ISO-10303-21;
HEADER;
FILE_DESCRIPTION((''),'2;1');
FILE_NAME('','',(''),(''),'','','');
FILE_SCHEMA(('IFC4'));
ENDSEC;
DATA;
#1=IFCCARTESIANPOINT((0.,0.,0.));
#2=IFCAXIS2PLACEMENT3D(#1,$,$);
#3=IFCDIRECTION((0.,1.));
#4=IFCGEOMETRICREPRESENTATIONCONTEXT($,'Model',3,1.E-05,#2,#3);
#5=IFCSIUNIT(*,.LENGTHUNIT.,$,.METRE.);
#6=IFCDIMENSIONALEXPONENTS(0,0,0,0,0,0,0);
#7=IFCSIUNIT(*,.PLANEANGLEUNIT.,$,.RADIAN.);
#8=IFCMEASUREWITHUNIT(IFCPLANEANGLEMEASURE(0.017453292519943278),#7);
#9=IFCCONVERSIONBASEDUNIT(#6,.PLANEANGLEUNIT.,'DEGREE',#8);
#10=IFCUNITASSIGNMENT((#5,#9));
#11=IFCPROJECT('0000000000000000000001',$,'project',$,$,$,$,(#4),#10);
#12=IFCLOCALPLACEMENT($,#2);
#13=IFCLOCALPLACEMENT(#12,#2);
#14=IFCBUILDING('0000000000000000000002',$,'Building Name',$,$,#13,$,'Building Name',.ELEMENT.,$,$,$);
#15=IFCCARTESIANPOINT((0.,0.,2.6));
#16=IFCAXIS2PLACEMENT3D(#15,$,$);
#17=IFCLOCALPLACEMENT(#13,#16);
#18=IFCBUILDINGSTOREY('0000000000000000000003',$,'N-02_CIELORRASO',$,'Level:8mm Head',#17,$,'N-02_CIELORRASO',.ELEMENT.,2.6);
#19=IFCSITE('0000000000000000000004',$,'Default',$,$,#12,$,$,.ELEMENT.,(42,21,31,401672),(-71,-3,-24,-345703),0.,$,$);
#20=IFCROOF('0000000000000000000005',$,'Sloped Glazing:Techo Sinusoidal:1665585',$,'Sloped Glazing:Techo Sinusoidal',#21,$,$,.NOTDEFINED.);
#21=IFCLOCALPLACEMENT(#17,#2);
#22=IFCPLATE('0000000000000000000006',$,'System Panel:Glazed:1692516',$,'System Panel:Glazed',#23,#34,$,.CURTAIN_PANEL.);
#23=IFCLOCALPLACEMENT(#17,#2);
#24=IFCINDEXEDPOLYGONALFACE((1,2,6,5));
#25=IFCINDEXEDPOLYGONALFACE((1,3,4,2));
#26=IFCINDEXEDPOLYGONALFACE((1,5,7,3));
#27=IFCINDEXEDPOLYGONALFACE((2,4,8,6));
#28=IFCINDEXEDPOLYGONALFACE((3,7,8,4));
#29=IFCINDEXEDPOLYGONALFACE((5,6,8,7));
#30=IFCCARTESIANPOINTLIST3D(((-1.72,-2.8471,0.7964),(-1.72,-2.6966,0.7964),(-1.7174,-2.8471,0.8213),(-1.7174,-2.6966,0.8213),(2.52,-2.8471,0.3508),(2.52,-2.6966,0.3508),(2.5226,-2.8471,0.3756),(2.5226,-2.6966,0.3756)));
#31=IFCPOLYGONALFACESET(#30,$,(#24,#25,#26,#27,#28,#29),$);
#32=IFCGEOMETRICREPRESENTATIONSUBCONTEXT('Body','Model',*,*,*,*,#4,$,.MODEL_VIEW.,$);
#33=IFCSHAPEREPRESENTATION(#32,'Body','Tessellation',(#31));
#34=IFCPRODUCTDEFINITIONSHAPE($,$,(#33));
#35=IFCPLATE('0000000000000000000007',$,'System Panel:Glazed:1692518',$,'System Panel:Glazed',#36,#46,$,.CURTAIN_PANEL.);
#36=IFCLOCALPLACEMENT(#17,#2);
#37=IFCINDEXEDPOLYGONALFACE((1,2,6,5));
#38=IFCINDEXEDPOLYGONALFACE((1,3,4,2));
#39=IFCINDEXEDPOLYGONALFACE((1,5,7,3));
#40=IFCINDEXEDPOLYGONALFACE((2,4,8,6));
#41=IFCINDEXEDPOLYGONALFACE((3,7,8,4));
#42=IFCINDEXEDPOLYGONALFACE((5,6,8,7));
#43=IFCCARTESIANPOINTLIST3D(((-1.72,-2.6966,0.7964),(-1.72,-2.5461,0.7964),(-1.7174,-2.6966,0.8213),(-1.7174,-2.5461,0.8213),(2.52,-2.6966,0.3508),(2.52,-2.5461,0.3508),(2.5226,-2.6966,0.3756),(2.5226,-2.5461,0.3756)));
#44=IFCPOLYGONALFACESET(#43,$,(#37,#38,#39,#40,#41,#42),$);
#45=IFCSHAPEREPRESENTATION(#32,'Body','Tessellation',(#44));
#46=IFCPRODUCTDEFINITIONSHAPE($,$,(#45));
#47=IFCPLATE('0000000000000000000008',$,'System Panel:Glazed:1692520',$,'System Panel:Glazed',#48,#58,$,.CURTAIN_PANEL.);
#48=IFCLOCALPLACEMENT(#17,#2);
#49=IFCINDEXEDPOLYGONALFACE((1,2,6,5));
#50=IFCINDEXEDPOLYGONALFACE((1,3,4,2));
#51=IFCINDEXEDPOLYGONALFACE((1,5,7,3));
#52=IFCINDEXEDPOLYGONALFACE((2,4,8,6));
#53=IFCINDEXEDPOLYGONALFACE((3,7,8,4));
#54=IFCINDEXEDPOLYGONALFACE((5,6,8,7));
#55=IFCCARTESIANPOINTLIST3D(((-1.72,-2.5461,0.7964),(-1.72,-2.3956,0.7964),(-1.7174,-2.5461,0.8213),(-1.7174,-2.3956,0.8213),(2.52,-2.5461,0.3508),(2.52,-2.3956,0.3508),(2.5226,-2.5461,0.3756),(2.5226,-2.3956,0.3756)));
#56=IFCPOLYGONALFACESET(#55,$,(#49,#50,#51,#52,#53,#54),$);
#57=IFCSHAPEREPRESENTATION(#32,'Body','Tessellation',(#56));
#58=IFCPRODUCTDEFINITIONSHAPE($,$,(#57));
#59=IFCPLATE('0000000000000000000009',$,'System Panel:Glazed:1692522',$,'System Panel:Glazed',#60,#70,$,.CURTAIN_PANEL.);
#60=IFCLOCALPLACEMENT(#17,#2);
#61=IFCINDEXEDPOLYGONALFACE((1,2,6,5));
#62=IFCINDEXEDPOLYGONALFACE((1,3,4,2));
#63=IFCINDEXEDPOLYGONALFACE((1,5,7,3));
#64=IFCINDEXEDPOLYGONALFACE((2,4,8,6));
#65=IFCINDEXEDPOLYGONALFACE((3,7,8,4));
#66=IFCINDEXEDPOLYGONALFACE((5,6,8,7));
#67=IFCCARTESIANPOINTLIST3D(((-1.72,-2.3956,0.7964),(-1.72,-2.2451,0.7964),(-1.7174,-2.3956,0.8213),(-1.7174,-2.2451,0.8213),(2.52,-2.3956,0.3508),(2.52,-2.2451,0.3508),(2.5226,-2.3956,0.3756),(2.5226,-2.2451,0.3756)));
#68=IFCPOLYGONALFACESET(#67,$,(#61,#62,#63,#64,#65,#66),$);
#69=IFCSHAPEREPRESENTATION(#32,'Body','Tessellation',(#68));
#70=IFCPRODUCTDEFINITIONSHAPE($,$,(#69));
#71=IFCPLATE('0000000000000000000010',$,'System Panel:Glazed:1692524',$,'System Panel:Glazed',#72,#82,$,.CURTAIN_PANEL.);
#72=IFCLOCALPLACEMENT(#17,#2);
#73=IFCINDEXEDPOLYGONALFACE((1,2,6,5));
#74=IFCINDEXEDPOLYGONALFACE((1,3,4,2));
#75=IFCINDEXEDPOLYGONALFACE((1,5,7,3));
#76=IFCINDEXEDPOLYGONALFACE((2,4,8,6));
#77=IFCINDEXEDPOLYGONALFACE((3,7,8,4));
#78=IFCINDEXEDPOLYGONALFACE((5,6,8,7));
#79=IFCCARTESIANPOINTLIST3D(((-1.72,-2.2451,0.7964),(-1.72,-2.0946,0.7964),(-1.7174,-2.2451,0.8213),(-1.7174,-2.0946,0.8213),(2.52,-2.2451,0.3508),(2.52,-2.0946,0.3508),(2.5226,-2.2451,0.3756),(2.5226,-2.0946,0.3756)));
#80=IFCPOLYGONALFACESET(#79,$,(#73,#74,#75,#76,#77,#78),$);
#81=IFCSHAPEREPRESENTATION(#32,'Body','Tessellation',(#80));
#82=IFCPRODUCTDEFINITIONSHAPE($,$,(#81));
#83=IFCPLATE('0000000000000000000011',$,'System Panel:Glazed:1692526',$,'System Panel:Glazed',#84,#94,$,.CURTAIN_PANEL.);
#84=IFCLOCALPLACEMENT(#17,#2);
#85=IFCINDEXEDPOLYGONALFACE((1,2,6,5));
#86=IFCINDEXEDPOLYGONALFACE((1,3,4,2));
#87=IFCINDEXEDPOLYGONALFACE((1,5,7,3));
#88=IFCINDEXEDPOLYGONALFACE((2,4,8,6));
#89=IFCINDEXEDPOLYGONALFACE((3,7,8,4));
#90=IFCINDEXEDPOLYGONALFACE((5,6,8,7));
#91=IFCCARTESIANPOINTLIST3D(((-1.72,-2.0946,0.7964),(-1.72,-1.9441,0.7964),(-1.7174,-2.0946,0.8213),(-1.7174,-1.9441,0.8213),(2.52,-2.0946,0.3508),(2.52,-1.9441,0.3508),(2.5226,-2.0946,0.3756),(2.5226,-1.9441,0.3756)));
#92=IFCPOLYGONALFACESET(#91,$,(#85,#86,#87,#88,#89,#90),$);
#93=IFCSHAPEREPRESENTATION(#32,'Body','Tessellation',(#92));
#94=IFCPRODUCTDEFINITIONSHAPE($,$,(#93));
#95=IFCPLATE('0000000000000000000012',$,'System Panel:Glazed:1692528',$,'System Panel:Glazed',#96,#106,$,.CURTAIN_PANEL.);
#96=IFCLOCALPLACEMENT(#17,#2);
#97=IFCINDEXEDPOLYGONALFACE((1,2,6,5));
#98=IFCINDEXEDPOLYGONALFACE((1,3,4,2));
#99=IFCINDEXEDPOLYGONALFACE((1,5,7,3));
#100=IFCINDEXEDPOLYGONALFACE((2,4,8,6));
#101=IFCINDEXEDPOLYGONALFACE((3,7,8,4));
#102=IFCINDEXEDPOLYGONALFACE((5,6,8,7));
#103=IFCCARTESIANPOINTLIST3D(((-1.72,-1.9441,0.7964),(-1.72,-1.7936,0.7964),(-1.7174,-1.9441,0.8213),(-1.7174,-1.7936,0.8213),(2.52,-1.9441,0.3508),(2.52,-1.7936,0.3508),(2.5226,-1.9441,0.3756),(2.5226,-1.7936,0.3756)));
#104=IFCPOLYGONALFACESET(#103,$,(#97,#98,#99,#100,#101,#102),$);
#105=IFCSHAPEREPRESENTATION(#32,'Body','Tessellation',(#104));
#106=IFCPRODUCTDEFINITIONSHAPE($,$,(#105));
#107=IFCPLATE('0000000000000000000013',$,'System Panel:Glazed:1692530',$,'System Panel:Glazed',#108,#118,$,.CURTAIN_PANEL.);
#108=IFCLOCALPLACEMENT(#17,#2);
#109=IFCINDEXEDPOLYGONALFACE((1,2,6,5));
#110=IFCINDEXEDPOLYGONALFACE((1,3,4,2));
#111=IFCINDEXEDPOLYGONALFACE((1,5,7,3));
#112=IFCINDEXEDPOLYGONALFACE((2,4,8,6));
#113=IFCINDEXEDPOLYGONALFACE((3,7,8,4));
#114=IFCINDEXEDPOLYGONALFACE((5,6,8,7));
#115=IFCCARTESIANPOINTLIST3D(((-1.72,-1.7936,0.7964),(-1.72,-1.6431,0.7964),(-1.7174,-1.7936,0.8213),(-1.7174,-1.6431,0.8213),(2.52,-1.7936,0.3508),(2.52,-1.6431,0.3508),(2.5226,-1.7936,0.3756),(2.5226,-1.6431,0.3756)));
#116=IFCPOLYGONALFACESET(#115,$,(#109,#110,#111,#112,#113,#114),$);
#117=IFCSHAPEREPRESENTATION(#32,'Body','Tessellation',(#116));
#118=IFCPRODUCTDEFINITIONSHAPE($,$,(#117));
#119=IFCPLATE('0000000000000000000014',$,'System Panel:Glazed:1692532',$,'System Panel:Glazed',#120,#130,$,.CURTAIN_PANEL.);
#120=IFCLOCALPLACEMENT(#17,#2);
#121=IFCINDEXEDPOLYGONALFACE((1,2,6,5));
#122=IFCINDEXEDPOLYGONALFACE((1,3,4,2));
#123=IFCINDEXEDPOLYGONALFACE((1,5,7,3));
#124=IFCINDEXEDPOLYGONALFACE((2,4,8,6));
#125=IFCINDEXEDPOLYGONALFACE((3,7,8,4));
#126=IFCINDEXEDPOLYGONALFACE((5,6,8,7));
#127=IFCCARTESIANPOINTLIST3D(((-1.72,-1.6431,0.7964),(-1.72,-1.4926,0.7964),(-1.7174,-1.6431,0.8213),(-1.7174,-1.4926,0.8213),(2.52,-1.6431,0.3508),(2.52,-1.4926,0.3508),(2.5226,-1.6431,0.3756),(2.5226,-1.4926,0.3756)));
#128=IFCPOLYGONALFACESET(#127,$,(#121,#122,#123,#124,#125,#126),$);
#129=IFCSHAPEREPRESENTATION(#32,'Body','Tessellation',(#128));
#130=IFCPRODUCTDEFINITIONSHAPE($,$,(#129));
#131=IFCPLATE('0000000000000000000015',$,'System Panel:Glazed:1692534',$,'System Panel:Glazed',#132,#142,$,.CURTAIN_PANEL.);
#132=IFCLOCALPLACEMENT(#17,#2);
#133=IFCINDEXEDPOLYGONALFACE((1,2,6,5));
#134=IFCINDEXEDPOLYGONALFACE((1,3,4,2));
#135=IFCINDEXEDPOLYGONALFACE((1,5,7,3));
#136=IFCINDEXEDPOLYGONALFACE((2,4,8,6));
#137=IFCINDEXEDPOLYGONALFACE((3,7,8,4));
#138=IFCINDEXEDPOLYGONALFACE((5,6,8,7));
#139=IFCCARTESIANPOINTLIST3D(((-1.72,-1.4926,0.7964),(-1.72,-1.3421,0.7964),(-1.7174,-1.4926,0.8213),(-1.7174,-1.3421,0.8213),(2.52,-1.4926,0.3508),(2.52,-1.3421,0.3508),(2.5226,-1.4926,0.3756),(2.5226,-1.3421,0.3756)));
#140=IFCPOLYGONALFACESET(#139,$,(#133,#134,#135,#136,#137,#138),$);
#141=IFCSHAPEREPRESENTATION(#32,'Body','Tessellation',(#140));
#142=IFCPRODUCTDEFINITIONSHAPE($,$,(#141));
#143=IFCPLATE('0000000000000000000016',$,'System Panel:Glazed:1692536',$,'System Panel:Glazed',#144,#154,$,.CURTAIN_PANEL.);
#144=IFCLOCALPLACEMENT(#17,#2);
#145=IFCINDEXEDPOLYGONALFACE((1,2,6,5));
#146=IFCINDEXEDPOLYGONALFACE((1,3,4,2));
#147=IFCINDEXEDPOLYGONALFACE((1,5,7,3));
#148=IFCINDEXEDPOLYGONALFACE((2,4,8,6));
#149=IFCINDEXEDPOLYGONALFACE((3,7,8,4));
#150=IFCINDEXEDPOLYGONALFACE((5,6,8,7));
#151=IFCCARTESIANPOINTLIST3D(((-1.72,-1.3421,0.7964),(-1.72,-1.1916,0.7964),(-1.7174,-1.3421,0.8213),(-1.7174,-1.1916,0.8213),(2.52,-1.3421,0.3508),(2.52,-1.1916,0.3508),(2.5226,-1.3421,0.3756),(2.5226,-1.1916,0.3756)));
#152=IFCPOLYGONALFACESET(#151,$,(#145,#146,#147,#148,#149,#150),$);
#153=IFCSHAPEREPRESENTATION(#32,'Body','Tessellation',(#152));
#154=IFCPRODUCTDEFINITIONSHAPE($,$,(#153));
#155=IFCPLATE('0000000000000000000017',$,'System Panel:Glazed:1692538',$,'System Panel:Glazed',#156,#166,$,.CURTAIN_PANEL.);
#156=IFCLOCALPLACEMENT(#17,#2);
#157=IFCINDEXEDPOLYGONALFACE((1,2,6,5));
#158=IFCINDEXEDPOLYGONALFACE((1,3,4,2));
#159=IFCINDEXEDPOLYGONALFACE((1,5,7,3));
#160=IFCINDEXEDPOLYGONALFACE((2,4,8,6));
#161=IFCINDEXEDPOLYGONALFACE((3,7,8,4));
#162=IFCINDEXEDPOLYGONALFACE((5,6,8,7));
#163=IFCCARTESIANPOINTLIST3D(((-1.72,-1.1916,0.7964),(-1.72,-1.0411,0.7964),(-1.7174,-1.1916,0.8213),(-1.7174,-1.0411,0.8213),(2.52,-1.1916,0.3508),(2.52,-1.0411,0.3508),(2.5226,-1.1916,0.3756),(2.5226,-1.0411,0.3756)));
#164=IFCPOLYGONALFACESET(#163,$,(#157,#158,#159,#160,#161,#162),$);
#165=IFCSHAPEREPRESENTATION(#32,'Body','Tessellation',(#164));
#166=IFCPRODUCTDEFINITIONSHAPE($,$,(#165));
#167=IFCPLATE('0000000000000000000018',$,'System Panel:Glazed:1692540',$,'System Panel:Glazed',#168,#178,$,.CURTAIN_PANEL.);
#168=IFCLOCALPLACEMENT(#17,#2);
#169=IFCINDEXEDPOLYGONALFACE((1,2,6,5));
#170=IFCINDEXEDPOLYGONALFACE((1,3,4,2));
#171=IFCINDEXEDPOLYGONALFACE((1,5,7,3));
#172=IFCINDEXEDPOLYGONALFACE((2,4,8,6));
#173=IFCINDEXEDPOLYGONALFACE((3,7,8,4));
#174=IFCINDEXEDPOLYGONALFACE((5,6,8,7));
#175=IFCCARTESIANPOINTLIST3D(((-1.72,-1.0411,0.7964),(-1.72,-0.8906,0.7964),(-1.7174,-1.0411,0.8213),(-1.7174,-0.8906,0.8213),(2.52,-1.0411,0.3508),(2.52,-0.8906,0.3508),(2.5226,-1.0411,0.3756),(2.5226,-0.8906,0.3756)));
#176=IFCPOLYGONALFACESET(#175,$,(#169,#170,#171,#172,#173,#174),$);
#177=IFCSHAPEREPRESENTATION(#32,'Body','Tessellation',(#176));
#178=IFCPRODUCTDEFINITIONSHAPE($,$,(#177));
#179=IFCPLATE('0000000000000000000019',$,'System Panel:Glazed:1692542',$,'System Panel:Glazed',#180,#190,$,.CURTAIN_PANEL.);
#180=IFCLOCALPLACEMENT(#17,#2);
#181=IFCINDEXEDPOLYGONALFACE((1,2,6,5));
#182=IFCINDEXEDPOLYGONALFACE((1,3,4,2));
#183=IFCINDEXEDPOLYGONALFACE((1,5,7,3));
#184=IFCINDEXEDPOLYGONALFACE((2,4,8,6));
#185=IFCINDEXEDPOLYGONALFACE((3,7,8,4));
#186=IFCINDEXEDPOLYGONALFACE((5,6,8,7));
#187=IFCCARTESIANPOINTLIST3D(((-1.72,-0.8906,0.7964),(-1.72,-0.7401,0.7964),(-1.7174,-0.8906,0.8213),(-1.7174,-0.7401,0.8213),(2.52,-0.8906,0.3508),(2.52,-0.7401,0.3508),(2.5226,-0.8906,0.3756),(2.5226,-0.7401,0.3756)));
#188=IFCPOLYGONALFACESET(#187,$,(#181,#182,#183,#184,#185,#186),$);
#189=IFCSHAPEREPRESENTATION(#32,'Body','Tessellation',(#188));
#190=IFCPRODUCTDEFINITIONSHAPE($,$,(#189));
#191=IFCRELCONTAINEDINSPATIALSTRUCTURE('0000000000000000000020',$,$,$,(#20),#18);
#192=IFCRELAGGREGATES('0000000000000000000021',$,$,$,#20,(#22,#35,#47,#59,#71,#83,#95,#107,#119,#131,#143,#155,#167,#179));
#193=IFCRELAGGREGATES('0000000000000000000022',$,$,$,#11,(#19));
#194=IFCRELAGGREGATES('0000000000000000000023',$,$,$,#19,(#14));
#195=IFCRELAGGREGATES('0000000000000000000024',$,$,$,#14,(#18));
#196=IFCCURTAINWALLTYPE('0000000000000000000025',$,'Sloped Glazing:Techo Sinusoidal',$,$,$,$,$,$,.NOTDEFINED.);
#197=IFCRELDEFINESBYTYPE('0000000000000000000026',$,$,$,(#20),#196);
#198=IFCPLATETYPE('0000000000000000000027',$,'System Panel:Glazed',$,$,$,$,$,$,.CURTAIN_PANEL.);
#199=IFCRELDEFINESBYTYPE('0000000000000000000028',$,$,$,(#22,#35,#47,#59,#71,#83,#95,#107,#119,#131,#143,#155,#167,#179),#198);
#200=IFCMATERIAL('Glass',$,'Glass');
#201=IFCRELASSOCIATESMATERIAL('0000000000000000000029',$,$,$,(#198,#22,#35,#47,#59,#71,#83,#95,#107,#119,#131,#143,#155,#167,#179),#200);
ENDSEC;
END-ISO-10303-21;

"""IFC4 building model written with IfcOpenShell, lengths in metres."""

from ifc_helpers import new_model, entity, si_unit, converted_unit, direction, frame, origin, place, context, subcontext, project, spatial, indexed_curve, outline, extrude, source, transform, mapped, material, type_object, type_shapes, element, aggregate, save


model = new_model("IFC4")

# Units and contexts
model_context = context("Model", 3, precision=1e-05, world=origin(), true_north=direction((0.0, 1.0)))
body_context = subcontext(model_context, "Body", "Model", "MODEL_VIEW")
ifc_project = project(units=[si_unit("LENGTHUNIT", "METRE"), converted_unit("PLANEANGLEUNIT", "DEGREE", entity("IfcPlaneAngleMeasure", 0.017453292519943278), si_unit("PLANEANGLEUNIT", "RADIAN"), dimensions=[0, 0, 0, 0, 0, 0, 0])], contexts=[model_context])

# Site, building, storey
site_placement = place(None, origin())
site = spatial("IfcSite", under=ifc_project, at=site_placement, Name="Default", CompositionType="ELEMENT", RefLatitude=(42, 21, 31, 401672), RefLongitude=(-71, -3, -24, -345703), RefElevation=0.0)
building_placement = place(site_placement, origin())
building = spatial("IfcBuilding", under=site, at=building_placement, Name="Building Name", LongName="Building Name", CompositionType="ELEMENT")
storey_placement = place(building_placement, frame((0.0, 0.0, 2.6)))
storey = spatial("IfcBuildingStorey", under=building, at=storey_placement, Name="N-02_CIELORRASO", ObjectType="Level:8mm Head", LongName="N-02_CIELORRASO", CompositionType="ELEMENT", Elevation=2.6)

# Roof, plates
curtain_wall_type = type_object("IfcCurtainWallType", Name="Sloped Glazing:Techo Sinusoidal", PredefinedType="NOTDEFINED")
roof_placement = place(storey_placement, frame((0.0, 0.0, -2.6)))
roof = element("IfcRoof", 1, at=roof_placement, inside=storey, type_object=curtain_wall_type, Name="Sloped Glazing:Techo Sinusoidal:1665585", ObjectType="Sloped Glazing:Techo Sinusoidal", PredefinedType="NOTDEFINED")
ifc_material_1 = material(Name="Glass", Category="Glass")
plate_type = type_object("IfcPlateType", Name="System Panel:Glazed", PredefinedType="CURTAIN_PANEL", material=ifc_material_1)
shared_shape_1 = source(origin(), body_context, "Body", "SweptSolid", [
    extrude(outline(indexed_curve([(-0.0125, -0.0752), (0.0125, -0.0752), (0.0125, 0.0752), (-0.0125, 0.0752), (-0.0125, -0.0752)], self_intersect=False)), frame((0.0, 0.037, 0.0), z_axis=(0.0, 0.0, 1.0), x_axis=(0.0, 1.0, 0.0)), (0.0, 0.0, 1.0), 4.2634),
])
type_shapes(plate_type, [shared_shape_1])
plate_1_placement = place(roof_placement, frame((2.5252, -2.7719, 3.0), z_axis=(-0.994522, 0.0, 0.104528), x_axis=(0.0, 1.0, 0.0)))
plate_1 = element("IfcPlate", 2, at=plate_1_placement, type_object=plate_type, material=ifc_material_1, Name="System Panel:Glazed:1692516", ObjectType="System Panel:Glazed", PredefinedType="CURTAIN_PANEL", context=body_context, shape_type="MappedRepresentation", body=[
    mapped(shared_shape_1, transform((0.0, 0.0, 0.0), scale=1.0)),
])
plate_2_placement = place(roof_placement, frame((2.5252, -2.6214, 3.0), z_axis=(-0.994522, 0.0, 0.104528), x_axis=(0.0, 1.0, 0.0)))
plate_2 = element("IfcPlate", 3, at=plate_2_placement, type_object=plate_type, material=ifc_material_1, Name="System Panel:Glazed:1692518", ObjectType="System Panel:Glazed", PredefinedType="CURTAIN_PANEL", context=body_context, shape_type="MappedRepresentation", body=[
    mapped(shared_shape_1, transform((0.0, 0.0, 0.0), scale=1.0)),
])
plate_3_placement = place(roof_placement, frame((2.5252, -2.4709, 3.0), z_axis=(-0.994522, 0.0, 0.104528), x_axis=(0.0, 1.0, 0.0)))
plate_3 = element("IfcPlate", 4, at=plate_3_placement, type_object=plate_type, material=ifc_material_1, Name="System Panel:Glazed:1692520", ObjectType="System Panel:Glazed", PredefinedType="CURTAIN_PANEL", context=body_context, shape_type="MappedRepresentation", body=[
    mapped(shared_shape_1, transform((0.0, 0.0, 0.0), scale=1.0)),
])
plate_4_placement = place(roof_placement, frame((2.5252, -2.3204, 3.0), z_axis=(-0.994522, 0.0, 0.104528), x_axis=(0.0, 1.0, 0.0)))
plate_4 = element("IfcPlate", 5, at=plate_4_placement, type_object=plate_type, material=ifc_material_1, Name="System Panel:Glazed:1692522", ObjectType="System Panel:Glazed", PredefinedType="CURTAIN_PANEL", context=body_context, shape_type="MappedRepresentation", body=[
    mapped(shared_shape_1, transform((0.0, 0.0, 0.0), scale=1.0)),
])
plate_5_placement = place(roof_placement, frame((2.5252, -2.1699, 3.0), z_axis=(-0.994522, 0.0, 0.104528), x_axis=(0.0, 1.0, 0.0)))
plate_5 = element("IfcPlate", 6, at=plate_5_placement, type_object=plate_type, material=ifc_material_1, Name="System Panel:Glazed:1692524", ObjectType="System Panel:Glazed", PredefinedType="CURTAIN_PANEL", context=body_context, shape_type="MappedRepresentation", body=[
    mapped(shared_shape_1, transform((0.0, 0.0, 0.0), scale=1.0)),
])
plate_6_placement = place(roof_placement, frame((2.5252, -2.0194, 3.0), z_axis=(-0.994522, 0.0, 0.104528), x_axis=(0.0, 1.0, 0.0)))
plate_6 = element("IfcPlate", 7, at=plate_6_placement, type_object=plate_type, material=ifc_material_1, Name="System Panel:Glazed:1692526", ObjectType="System Panel:Glazed", PredefinedType="CURTAIN_PANEL", context=body_context, shape_type="MappedRepresentation", body=[
    mapped(shared_shape_1, transform((0.0, 0.0, 0.0), scale=1.0)),
])
plate_7_placement = place(roof_placement, frame((2.5252, -1.8689, 3.0), z_axis=(-0.994522, 0.0, 0.104528), x_axis=(0.0, 1.0, 0.0)))
plate_7 = element("IfcPlate", 8, at=plate_7_placement, type_object=plate_type, material=ifc_material_1, Name="System Panel:Glazed:1692528", ObjectType="System Panel:Glazed", PredefinedType="CURTAIN_PANEL", context=body_context, shape_type="MappedRepresentation", body=[
    mapped(shared_shape_1, transform((0.0, 0.0, 0.0), scale=1.0)),
])
plate_8_placement = place(roof_placement, frame((2.5252, -1.7184, 3.0), z_axis=(-0.994522, 0.0, 0.104528), x_axis=(0.0, 1.0, 0.0)))
plate_8 = element("IfcPlate", 9, at=plate_8_placement, type_object=plate_type, material=ifc_material_1, Name="System Panel:Glazed:1692530", ObjectType="System Panel:Glazed", PredefinedType="CURTAIN_PANEL", context=body_context, shape_type="MappedRepresentation", body=[
    mapped(shared_shape_1, transform((0.0, 0.0, 0.0), scale=1.0)),
])
plate_9_placement = place(roof_placement, frame((2.5252, -1.5679, 3.0), z_axis=(-0.994522, 0.0, 0.104528), x_axis=(0.0, 1.0, 0.0)))
plate_9 = element("IfcPlate", 10, at=plate_9_placement, type_object=plate_type, material=ifc_material_1, Name="System Panel:Glazed:1692532", ObjectType="System Panel:Glazed", PredefinedType="CURTAIN_PANEL", context=body_context, shape_type="MappedRepresentation", body=[
    mapped(shared_shape_1, transform((0.0, 0.0, 0.0), scale=1.0)),
])
plate_10_placement = place(roof_placement, frame((2.5252, -1.4174, 3.0), z_axis=(-0.994522, 0.0, 0.104528), x_axis=(0.0, 1.0, 0.0)))
plate_10 = element("IfcPlate", 11, at=plate_10_placement, type_object=plate_type, material=ifc_material_1, Name="System Panel:Glazed:1692534", ObjectType="System Panel:Glazed", PredefinedType="CURTAIN_PANEL", context=body_context, shape_type="MappedRepresentation", body=[
    mapped(shared_shape_1, transform((0.0, 0.0, 0.0), scale=1.0)),
])
plate_11_placement = place(roof_placement, frame((2.5252, -1.2669, 3.0), z_axis=(-0.994522, 0.0, 0.104528), x_axis=(0.0, 1.0, 0.0)))
plate_11 = element("IfcPlate", 12, at=plate_11_placement, type_object=plate_type, material=ifc_material_1, Name="System Panel:Glazed:1692536", ObjectType="System Panel:Glazed", PredefinedType="CURTAIN_PANEL", context=body_context, shape_type="MappedRepresentation", body=[
    mapped(shared_shape_1, transform((0.0, 0.0, 0.0), scale=1.0)),
])
plate_12_placement = place(roof_placement, frame((2.5252, -1.1164, 3.0), z_axis=(-0.994522, 0.0, 0.104528), x_axis=(0.0, 1.0, 0.0)))
plate_12 = element("IfcPlate", 13, at=plate_12_placement, type_object=plate_type, material=ifc_material_1, Name="System Panel:Glazed:1692538", ObjectType="System Panel:Glazed", PredefinedType="CURTAIN_PANEL", context=body_context, shape_type="MappedRepresentation", body=[
    mapped(shared_shape_1, transform((0.0, 0.0, 0.0), scale=1.0)),
])
plate_13_placement = place(roof_placement, frame((2.5252, -0.9659, 3.0), z_axis=(-0.994522, 0.0, 0.104528), x_axis=(0.0, 1.0, 0.0)))
plate_13 = element("IfcPlate", 14, at=plate_13_placement, type_object=plate_type, material=ifc_material_1, Name="System Panel:Glazed:1692540", ObjectType="System Panel:Glazed", PredefinedType="CURTAIN_PANEL", context=body_context, shape_type="MappedRepresentation", body=[
    mapped(shared_shape_1, transform((0.0, 0.0, 0.0), scale=1.0)),
])
plate_14_placement = place(roof_placement, frame((2.5252, -0.8154, 3.0), z_axis=(-0.994522, 0.0, 0.104528), x_axis=(0.0, 1.0, 0.0)))
plate_14 = element("IfcPlate", 15, at=plate_14_placement, type_object=plate_type, material=ifc_material_1, Name="System Panel:Glazed:1692542", ObjectType="System Panel:Glazed", PredefinedType="CURTAIN_PANEL", context=body_context, shape_type="MappedRepresentation", body=[
    mapped(shared_shape_1, transform((0.0, 0.0, 0.0), scale=1.0)),
])
aggregate(roof, [plate_1, plate_2, plate_3, plate_4, plate_5, plate_6, plate_7, plate_8, plate_9, plate_10, plate_11, plate_12, plate_13, plate_14])

save(model, "model.ifc")
